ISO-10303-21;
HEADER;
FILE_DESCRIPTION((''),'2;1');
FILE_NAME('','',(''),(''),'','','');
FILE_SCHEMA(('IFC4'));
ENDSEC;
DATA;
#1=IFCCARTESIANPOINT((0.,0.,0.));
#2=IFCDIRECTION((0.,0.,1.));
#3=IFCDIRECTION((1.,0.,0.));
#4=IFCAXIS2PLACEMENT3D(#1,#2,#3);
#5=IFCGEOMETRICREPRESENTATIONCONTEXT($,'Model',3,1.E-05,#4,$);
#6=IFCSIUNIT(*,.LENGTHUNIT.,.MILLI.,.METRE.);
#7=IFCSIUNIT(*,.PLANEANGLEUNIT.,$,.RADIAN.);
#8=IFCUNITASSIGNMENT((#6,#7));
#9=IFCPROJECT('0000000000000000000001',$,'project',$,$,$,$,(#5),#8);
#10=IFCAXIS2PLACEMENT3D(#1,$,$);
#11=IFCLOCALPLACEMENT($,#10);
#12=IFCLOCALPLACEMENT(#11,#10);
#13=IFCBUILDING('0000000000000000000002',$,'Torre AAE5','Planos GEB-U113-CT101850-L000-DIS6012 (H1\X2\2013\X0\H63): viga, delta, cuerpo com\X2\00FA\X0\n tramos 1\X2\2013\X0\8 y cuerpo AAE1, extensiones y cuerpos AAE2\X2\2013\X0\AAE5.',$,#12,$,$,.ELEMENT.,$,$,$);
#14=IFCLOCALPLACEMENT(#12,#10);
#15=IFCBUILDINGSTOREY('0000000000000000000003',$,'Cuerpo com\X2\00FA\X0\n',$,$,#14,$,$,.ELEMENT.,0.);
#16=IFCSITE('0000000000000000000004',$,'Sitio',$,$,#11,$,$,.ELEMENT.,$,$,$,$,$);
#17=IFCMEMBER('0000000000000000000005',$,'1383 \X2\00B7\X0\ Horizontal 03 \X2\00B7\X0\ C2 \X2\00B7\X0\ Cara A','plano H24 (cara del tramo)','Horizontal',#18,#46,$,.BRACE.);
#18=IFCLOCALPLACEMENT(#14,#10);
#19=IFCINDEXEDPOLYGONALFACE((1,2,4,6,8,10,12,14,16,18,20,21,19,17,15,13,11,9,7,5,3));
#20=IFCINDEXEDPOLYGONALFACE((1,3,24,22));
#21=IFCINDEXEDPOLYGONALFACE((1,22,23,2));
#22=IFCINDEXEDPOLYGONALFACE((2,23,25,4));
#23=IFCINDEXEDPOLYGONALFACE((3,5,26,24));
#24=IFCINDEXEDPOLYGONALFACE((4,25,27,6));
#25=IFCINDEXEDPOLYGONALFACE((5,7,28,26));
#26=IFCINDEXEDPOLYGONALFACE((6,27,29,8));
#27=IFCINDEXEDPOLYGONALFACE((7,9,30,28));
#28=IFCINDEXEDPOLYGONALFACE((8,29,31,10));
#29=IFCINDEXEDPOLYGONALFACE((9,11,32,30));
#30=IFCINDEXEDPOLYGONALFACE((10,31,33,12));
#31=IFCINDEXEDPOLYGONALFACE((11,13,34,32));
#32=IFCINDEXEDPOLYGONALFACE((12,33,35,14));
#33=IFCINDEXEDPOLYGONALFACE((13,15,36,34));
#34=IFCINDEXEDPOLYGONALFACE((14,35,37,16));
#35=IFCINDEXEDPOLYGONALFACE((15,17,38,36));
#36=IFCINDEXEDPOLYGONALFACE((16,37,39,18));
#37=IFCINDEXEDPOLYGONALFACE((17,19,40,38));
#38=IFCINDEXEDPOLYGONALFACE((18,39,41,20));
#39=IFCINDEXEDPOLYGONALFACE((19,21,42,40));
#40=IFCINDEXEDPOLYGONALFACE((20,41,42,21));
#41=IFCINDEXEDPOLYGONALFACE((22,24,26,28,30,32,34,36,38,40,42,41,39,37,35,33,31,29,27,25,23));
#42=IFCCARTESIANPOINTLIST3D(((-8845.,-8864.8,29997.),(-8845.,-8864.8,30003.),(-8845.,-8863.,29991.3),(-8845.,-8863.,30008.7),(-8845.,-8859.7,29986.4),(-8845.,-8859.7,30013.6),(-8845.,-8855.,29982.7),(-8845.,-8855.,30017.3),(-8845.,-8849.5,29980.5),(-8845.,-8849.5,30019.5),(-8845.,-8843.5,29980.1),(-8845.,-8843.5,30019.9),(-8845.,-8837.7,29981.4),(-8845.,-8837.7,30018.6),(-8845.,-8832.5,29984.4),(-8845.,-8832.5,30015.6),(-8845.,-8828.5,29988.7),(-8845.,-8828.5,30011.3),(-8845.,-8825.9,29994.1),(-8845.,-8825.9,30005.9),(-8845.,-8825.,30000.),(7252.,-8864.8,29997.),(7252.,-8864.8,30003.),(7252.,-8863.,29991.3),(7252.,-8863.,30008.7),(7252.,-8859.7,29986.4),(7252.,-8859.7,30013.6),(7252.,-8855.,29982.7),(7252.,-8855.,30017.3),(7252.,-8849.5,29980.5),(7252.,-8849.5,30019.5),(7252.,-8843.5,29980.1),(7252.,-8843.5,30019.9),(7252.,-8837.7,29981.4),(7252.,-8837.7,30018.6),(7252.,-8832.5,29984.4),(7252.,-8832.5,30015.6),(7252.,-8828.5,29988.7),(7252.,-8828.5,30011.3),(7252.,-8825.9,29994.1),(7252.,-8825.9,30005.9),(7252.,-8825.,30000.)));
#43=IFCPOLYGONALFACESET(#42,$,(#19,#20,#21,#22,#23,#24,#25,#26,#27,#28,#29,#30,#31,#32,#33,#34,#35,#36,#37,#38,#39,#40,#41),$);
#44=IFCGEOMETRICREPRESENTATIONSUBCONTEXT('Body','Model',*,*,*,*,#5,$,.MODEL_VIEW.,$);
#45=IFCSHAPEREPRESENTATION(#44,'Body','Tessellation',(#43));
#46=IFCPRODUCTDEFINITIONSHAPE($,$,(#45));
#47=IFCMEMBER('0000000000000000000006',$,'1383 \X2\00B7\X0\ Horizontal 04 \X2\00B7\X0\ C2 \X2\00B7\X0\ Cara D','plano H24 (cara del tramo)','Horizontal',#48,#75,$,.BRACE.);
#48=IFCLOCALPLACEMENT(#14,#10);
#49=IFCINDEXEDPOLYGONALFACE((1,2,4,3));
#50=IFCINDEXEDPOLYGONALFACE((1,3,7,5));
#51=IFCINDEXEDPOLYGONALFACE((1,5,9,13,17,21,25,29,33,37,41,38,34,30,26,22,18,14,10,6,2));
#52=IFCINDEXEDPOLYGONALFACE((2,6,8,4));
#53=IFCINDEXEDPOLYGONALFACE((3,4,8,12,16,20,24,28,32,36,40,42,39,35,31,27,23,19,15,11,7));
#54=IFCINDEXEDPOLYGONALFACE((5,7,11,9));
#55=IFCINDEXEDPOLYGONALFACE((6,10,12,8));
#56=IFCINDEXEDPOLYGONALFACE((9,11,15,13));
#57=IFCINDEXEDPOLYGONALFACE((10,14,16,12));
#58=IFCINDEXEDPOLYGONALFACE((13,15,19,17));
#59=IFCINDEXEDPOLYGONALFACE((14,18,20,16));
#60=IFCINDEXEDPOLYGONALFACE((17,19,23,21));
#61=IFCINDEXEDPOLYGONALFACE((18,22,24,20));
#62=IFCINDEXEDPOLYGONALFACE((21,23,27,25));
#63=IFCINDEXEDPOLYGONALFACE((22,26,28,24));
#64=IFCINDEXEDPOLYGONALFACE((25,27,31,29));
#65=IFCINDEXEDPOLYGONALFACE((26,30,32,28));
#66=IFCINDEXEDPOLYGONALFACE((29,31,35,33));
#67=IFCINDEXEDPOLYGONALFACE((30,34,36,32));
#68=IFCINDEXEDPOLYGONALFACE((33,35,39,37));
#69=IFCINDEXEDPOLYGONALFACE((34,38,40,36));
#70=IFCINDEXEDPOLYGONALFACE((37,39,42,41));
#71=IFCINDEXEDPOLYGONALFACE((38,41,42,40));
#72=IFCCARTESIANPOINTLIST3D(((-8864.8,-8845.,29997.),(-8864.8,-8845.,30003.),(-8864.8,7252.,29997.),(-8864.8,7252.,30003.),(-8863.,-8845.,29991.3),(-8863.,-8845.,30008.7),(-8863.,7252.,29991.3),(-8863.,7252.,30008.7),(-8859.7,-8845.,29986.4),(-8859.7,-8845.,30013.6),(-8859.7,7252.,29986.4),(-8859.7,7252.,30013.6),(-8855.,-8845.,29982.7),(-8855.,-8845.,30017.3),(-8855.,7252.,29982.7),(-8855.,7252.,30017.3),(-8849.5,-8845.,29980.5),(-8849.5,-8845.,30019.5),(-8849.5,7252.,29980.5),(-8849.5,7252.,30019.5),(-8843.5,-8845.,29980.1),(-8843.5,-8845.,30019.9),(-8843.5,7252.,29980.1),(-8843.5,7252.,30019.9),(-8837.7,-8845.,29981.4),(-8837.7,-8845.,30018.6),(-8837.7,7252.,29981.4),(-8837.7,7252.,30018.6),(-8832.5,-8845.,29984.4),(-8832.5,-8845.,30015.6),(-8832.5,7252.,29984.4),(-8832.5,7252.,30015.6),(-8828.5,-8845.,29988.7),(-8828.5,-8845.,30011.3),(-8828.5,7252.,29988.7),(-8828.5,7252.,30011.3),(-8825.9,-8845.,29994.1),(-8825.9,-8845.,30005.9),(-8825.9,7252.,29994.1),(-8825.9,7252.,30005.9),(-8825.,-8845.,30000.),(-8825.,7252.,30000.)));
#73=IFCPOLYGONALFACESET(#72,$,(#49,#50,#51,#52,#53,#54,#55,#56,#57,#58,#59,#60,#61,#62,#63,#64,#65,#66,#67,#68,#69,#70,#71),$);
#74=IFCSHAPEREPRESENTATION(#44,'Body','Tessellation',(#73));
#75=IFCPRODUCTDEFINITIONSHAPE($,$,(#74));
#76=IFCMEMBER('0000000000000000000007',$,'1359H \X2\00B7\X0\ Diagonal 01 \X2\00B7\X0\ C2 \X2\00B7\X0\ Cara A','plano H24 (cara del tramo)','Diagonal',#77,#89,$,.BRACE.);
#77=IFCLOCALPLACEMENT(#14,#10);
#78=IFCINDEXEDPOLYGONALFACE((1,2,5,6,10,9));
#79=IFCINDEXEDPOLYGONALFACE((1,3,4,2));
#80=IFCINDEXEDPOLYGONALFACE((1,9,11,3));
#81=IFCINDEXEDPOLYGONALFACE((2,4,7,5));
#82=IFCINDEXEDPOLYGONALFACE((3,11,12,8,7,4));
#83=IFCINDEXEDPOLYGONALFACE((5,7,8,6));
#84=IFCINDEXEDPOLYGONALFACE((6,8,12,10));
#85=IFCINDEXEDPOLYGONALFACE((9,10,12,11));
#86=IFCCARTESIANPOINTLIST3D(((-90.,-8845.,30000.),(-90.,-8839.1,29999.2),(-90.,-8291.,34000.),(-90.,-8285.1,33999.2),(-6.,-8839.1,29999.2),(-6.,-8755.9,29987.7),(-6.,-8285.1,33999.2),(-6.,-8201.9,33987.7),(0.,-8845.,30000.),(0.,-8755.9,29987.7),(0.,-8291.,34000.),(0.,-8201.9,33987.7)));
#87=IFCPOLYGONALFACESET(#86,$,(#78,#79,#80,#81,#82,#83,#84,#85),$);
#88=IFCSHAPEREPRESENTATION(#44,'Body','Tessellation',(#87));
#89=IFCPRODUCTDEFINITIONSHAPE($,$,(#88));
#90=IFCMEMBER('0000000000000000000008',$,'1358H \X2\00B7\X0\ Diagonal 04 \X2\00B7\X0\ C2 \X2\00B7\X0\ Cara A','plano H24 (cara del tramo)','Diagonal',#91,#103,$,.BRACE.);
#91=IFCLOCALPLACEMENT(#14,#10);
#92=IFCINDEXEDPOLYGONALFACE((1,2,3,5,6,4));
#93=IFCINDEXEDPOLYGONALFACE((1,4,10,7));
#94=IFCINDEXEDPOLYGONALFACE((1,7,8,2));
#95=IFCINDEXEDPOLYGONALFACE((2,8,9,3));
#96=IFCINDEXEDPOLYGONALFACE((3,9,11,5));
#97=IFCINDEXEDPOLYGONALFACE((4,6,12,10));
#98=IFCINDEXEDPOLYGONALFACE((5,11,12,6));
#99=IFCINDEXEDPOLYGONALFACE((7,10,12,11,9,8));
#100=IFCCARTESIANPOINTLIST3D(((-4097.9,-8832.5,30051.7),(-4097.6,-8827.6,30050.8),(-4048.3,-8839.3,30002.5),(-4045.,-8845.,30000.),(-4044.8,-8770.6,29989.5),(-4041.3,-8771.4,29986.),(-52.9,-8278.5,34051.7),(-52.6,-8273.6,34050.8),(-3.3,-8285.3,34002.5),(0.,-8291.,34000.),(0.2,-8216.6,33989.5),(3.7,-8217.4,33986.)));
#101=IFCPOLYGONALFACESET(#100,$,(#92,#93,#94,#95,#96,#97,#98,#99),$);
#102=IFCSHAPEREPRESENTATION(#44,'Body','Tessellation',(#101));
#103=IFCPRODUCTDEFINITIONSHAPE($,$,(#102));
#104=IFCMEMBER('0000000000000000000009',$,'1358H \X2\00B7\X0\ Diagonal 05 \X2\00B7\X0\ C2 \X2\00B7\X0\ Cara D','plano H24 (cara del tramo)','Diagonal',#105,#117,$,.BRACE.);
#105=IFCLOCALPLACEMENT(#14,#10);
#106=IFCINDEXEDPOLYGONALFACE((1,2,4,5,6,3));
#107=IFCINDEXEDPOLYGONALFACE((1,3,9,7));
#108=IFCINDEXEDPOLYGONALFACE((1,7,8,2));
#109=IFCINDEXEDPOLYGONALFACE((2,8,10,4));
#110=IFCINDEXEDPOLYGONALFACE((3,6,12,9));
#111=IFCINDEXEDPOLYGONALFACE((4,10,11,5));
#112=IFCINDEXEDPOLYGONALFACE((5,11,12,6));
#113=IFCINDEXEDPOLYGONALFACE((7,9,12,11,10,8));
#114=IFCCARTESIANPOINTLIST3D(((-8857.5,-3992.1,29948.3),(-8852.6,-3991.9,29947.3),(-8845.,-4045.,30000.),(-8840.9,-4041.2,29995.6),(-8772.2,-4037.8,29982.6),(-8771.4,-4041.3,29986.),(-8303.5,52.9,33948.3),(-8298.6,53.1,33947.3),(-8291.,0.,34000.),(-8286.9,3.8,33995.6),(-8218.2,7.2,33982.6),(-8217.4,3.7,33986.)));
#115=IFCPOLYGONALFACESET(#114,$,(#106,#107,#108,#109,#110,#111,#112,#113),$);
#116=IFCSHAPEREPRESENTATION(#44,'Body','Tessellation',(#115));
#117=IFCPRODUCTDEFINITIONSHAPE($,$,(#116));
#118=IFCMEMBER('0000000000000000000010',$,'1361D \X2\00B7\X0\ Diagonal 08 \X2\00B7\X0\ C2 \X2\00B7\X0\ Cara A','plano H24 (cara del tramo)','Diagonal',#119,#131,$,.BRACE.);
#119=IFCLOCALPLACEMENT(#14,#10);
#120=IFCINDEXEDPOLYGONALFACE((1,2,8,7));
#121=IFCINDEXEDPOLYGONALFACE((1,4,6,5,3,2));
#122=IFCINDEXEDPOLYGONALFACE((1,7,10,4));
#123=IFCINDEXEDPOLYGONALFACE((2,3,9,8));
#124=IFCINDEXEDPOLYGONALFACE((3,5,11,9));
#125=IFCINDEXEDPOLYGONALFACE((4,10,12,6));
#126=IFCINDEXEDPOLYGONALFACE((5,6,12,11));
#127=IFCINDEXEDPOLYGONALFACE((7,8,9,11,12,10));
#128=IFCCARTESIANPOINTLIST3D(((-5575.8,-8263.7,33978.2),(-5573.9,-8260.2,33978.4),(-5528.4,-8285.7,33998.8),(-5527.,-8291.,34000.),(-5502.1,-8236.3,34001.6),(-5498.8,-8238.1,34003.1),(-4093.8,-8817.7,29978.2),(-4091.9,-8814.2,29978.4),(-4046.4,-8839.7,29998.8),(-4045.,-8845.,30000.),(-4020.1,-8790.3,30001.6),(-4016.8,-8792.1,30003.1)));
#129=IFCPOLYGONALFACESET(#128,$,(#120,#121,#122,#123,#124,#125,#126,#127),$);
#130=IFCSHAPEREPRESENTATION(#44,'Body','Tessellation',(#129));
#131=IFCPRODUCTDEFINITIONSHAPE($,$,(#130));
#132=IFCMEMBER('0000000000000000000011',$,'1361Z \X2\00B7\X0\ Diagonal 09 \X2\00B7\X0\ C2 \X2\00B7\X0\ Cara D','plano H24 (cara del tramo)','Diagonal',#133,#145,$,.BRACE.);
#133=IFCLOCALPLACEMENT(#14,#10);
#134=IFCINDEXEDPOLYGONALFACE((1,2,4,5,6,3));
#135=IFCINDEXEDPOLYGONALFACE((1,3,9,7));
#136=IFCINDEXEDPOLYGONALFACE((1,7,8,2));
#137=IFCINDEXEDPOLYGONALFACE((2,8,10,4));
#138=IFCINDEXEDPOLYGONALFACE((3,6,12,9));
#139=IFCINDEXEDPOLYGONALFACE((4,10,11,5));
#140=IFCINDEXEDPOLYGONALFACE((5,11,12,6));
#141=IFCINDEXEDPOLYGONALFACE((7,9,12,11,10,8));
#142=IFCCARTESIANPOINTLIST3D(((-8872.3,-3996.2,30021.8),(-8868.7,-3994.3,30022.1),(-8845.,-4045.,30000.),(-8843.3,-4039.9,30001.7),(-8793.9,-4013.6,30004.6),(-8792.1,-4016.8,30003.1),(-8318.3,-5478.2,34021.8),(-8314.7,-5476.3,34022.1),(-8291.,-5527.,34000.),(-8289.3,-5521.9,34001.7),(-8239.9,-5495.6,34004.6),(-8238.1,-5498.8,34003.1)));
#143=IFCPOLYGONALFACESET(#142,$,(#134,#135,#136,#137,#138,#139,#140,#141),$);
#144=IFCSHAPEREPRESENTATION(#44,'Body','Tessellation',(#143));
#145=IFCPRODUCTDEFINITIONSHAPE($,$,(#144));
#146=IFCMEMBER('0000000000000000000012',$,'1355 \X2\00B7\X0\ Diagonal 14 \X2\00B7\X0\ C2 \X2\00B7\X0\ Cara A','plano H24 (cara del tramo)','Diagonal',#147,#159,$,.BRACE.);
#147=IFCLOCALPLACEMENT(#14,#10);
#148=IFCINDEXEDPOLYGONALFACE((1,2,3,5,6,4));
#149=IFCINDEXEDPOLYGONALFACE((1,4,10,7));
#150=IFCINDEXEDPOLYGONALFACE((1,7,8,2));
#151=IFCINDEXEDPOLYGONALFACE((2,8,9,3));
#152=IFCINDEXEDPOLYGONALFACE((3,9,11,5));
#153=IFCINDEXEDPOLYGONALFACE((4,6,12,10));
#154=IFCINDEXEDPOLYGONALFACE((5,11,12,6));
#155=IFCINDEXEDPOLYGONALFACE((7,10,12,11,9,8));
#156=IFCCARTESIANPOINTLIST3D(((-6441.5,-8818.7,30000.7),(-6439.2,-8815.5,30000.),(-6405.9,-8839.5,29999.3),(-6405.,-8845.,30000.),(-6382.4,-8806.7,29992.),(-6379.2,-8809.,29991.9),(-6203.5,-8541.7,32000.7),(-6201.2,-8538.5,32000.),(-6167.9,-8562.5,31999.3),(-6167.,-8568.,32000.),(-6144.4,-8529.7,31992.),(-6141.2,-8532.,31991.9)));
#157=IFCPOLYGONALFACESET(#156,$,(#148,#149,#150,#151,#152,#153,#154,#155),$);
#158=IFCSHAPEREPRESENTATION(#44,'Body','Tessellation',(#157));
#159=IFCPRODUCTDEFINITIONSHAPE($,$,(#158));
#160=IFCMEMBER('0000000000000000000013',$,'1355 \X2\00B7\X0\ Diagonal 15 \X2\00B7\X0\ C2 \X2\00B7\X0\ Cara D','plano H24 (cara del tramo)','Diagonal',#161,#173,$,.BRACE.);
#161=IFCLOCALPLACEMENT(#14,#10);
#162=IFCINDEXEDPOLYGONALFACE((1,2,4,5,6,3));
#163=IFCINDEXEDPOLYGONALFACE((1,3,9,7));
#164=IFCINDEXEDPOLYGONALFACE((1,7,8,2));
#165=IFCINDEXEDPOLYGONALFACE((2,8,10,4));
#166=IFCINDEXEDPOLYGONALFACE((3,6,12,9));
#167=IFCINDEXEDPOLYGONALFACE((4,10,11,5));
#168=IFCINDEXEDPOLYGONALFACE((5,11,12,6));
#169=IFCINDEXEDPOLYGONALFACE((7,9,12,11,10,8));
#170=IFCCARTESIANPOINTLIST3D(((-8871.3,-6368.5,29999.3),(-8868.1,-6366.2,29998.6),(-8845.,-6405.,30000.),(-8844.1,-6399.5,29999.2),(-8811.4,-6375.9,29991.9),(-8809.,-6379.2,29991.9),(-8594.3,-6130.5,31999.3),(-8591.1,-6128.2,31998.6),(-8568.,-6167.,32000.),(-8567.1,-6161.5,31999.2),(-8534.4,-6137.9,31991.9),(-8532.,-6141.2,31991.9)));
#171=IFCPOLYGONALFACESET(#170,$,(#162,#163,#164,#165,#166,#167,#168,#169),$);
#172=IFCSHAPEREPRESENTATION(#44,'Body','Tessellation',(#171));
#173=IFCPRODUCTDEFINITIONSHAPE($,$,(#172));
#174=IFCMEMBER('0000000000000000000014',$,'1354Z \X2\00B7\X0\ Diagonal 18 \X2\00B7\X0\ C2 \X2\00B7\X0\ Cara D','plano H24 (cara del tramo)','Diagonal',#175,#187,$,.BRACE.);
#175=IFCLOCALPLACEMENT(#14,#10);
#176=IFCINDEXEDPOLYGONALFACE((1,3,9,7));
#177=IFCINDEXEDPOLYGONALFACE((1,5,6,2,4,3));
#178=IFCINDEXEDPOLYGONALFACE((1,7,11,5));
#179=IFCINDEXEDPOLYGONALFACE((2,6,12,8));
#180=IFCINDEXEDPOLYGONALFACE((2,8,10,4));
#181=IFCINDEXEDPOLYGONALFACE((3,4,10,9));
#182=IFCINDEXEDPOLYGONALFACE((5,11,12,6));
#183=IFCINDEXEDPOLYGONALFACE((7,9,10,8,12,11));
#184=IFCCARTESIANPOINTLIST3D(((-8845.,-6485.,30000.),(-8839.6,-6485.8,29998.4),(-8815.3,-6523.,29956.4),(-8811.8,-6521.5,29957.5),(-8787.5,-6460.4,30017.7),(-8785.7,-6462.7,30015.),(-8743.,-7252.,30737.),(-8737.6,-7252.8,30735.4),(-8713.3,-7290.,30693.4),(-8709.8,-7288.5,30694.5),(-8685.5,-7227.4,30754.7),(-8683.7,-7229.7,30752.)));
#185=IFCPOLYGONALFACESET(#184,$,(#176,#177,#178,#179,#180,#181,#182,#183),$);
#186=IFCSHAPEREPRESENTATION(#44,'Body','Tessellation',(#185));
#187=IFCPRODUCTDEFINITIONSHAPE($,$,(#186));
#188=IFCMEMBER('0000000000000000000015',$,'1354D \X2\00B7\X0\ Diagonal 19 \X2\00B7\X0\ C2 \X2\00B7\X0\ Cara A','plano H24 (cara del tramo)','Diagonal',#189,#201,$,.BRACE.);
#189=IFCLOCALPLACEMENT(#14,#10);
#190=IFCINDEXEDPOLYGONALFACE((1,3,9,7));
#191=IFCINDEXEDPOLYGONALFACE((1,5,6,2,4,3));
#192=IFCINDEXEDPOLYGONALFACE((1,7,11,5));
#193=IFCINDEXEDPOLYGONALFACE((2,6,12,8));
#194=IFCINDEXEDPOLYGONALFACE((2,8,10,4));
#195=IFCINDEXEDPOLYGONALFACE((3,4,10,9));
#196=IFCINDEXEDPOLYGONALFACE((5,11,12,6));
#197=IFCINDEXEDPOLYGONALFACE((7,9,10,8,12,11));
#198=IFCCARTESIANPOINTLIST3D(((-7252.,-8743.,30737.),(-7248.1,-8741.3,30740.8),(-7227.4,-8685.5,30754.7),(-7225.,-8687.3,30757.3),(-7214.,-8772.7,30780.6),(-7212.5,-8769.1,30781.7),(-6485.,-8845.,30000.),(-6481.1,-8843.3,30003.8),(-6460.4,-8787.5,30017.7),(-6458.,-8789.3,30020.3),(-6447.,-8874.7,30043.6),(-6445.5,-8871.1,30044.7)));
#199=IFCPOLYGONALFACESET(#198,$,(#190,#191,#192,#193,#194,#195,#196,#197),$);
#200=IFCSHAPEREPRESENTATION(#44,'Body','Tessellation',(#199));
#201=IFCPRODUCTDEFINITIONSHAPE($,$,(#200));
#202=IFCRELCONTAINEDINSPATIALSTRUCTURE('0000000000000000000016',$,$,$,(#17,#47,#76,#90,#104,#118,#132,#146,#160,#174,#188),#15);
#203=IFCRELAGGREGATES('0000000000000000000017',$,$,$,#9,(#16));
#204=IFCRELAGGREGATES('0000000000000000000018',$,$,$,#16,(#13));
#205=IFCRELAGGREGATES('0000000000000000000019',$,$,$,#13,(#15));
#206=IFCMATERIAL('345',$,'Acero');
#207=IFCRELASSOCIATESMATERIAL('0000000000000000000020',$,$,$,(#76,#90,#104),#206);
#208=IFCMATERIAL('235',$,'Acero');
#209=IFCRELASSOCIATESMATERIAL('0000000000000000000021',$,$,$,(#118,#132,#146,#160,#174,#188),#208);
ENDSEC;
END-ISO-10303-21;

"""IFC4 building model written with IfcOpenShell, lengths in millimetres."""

from ifc_helpers import new_model, si_unit, frame, frame_2d, origin, origin_with_axes, place, context, subcontext, project, spatial, circle, l_section, extrude, material, element, save


model = new_model("IFC4")

# Units and contexts
model_context = context("Model", 3, precision=1e-05, world=origin_with_axes())
body_context = subcontext(model_context, "Body", "Model", "MODEL_VIEW")
ifc_project = project(units=[si_unit("LENGTHUNIT", "METRE", prefix="MILLI"), si_unit("PLANEANGLEUNIT", "RADIAN")], contexts=[model_context])

# Site, building, storey
site_placement = place(None, origin())
site = spatial("IfcSite", under=ifc_project, at=site_placement, Name="Sitio", CompositionType="ELEMENT")
building_placement = place(site_placement, origin())
building = spatial("IfcBuilding", under=site, at=building_placement, Name="Torre AAE5", Description="Planos GEB-U113-CT101850-L000-DIS6012 (H1–H63): viga, delta, cuerpo común tramos 1–8 y cuerpo AAE1, extensiones y cuerpos AAE2–AAE5.", CompositionType="ELEMENT")
storey_placement = place(building_placement, origin())
storey = spatial("IfcBuildingStorey", under=building, at=storey_placement, Name="Cuerpo común", CompositionType="ELEMENT", Elevation=0.0)

# Members
for number, where, z_axis, x_axis, name in (
    (1, (-8845.0, -8845.0, 30000.0), (1.0, 0.0, 0.0), (0.0, 1.0, 0.0), "1383 · Horizontal 03 · C2 · Cara A"),
    (2, (-8845.0, -8845.0, 30000.0), (0.0, 1.0, 0.0), (1.0, 0.0, 0.0), "1383 · Horizontal 04 · C2 · Cara D"),
):
    element("IfcMember", number, at=place(storey_placement, frame(where, z_axis=z_axis, x_axis=x_axis)), inside=storey, Name=name, Description="plano H24 (cara del tramo)", ObjectType="Horizontal", PredefinedType="BRACE", context=body_context, shape_type="SweptSolid", body=[
        extrude(circle(Radius=20.0), None, (0.0, 0.0, 1.0), 16097.0),
    ])
ifc_material_1 = material(Name="345", Category="Acero")
member_1_placement = place(storey_placement, frame((0.0, -8845.0, 30000.0), z_axis=(0.0, 0.13719, 0.990545), x_axis=(0.0, 0.990545, -0.13719)))
element("IfcMember", 3, at=member_1_placement, inside=storey, material=ifc_material_1, Name="1359H · Diagonal 01 · C2 · Cara A", Description="plano H24 (cara del tramo)", ObjectType="Diagonal", PredefinedType="BRACE", context=body_context, shape_type="SweptSolid", body=[
    extrude(l_section(Depth=90.0, Width=90.0, Thickness=6.0, at=frame_2d((45.0, 45.0))), None, (0.0, 0.0, 1.0), 4038.2),
])
for number, where, z_axis, x_axis, name in (
    (4, (-4045.0, -8845.0, 30000.0), (0.707703, 0.096926, 0.69983), (0.04958, 0.981289, -0.186046), "1358H · Diagonal 04 · C2 · Cara A"),
    (5, (-8845.0, -4045.0, 30000.0), (0.096926, 0.707703, 0.69983), (0.981289, 0.04958, -0.186046), "1358H · Diagonal 05 · C2 · Cara D"),
):
    element("IfcMember", number, at=place(storey_placement, frame(where, z_axis=z_axis, x_axis=x_axis)), inside=storey, material=ifc_material_1, Name=name, Description="plano H24 (cara del tramo)", ObjectType="Diagonal", PredefinedType="BRACE", context=body_context, shape_type="SweptSolid", body=[
        extrude(l_section(Depth=75.0, Width=75.0, Thickness=5.0, at=frame_2d((37.5, 37.5))), None, (0.0, 0.0, 1.0), 5715.7),
    ])
ifc_material_2 = material(Name="235", Category="Acero")
for number, where, z_axis, x_axis, name in (
    (6, (-4045.0, -8845.0, 30000.0), (-0.344528, 0.128791, 0.9299), (0.469244, 0.88155, 0.05176), "1361D · Diagonal 08 · C2 · Cara A"),
    (7, (-8845.0, -4045.0, 30000.0), (0.128791, -0.344528, 0.9299), (0.88155, 0.469244, 0.05176), "1361Z · Diagonal 09 · C2 · Cara D"),
):
    element("IfcMember", number, at=place(storey_placement, frame(where, z_axis=z_axis, x_axis=x_axis)), inside=storey, material=ifc_material_2, Name=name, Description="plano H24 (cara del tramo)", ObjectType="Diagonal", PredefinedType="BRACE", context=body_context, shape_type="SweptSolid", body=[
        extrude(l_section(Depth=60.0, Width=60.0, Thickness=4.0, at=frame_2d((30.0, 30.0))), None, (0.0, 0.0, 1.0), 4301.5),
    ])
for number, where, z_axis, x_axis, name in (
    (8, (-6405.0, -8845.0, 30000.0), (0.117064, 0.136247, 0.983734), (0.573677, 0.79929, -0.178969), "1355 · Diagonal 14 · C2 · Cara A"),
    (9, (-8845.0, -6405.0, 30000.0), (0.136247, 0.117064, 0.983734), (0.79929, 0.573677, -0.178969), "1355 · Diagonal 15 · C2 · Cara D"),
):
    element("IfcMember", number, at=place(storey_placement, frame(where, z_axis=z_axis, x_axis=x_axis)), inside=storey, material=ifc_material_2, Name=name, Description="plano H24 (cara del tramo)", ObjectType="Diagonal", PredefinedType="BRACE", context=body_context, shape_type="SweptSolid", body=[
        extrude(l_section(Depth=45.0, Width=45.0, Thickness=4.0, at=frame_2d((22.5, 22.5))), None, (0.0, 0.0, 1.0), 2033.1),
    ])
for number, where, z_axis, x_axis, name in (
    (10, (-8743.0, -7252.0, 30737.0), (-0.095454, 0.717775, -0.689701), (0.884687, 0.378781, 0.27176), "1354Z · Diagonal 18 · C2 · Cara D"),
    (11, (-7252.0, -8743.0, 30737.0), (0.717775, -0.095454, -0.689701), (0.378781, 0.884687, 0.27176), "1354D · Diagonal 19 · C2 · Cara A"),
):
    element("IfcMember", number, at=place(storey_placement, frame(where, z_axis=z_axis, x_axis=x_axis)), inside=storey, material=ifc_material_2, Name=name, Description="plano H24 (cara del tramo)", ObjectType="Diagonal", PredefinedType="BRACE", context=body_context, shape_type="SweptSolid", body=[
        extrude(l_section(Depth=65.0, Width=65.0, Thickness=4.0, at=frame_2d((32.5, 32.5))), None, (0.0, 0.0, 1.0), 1068.6),
    ])

save(model, "model.ifc")
